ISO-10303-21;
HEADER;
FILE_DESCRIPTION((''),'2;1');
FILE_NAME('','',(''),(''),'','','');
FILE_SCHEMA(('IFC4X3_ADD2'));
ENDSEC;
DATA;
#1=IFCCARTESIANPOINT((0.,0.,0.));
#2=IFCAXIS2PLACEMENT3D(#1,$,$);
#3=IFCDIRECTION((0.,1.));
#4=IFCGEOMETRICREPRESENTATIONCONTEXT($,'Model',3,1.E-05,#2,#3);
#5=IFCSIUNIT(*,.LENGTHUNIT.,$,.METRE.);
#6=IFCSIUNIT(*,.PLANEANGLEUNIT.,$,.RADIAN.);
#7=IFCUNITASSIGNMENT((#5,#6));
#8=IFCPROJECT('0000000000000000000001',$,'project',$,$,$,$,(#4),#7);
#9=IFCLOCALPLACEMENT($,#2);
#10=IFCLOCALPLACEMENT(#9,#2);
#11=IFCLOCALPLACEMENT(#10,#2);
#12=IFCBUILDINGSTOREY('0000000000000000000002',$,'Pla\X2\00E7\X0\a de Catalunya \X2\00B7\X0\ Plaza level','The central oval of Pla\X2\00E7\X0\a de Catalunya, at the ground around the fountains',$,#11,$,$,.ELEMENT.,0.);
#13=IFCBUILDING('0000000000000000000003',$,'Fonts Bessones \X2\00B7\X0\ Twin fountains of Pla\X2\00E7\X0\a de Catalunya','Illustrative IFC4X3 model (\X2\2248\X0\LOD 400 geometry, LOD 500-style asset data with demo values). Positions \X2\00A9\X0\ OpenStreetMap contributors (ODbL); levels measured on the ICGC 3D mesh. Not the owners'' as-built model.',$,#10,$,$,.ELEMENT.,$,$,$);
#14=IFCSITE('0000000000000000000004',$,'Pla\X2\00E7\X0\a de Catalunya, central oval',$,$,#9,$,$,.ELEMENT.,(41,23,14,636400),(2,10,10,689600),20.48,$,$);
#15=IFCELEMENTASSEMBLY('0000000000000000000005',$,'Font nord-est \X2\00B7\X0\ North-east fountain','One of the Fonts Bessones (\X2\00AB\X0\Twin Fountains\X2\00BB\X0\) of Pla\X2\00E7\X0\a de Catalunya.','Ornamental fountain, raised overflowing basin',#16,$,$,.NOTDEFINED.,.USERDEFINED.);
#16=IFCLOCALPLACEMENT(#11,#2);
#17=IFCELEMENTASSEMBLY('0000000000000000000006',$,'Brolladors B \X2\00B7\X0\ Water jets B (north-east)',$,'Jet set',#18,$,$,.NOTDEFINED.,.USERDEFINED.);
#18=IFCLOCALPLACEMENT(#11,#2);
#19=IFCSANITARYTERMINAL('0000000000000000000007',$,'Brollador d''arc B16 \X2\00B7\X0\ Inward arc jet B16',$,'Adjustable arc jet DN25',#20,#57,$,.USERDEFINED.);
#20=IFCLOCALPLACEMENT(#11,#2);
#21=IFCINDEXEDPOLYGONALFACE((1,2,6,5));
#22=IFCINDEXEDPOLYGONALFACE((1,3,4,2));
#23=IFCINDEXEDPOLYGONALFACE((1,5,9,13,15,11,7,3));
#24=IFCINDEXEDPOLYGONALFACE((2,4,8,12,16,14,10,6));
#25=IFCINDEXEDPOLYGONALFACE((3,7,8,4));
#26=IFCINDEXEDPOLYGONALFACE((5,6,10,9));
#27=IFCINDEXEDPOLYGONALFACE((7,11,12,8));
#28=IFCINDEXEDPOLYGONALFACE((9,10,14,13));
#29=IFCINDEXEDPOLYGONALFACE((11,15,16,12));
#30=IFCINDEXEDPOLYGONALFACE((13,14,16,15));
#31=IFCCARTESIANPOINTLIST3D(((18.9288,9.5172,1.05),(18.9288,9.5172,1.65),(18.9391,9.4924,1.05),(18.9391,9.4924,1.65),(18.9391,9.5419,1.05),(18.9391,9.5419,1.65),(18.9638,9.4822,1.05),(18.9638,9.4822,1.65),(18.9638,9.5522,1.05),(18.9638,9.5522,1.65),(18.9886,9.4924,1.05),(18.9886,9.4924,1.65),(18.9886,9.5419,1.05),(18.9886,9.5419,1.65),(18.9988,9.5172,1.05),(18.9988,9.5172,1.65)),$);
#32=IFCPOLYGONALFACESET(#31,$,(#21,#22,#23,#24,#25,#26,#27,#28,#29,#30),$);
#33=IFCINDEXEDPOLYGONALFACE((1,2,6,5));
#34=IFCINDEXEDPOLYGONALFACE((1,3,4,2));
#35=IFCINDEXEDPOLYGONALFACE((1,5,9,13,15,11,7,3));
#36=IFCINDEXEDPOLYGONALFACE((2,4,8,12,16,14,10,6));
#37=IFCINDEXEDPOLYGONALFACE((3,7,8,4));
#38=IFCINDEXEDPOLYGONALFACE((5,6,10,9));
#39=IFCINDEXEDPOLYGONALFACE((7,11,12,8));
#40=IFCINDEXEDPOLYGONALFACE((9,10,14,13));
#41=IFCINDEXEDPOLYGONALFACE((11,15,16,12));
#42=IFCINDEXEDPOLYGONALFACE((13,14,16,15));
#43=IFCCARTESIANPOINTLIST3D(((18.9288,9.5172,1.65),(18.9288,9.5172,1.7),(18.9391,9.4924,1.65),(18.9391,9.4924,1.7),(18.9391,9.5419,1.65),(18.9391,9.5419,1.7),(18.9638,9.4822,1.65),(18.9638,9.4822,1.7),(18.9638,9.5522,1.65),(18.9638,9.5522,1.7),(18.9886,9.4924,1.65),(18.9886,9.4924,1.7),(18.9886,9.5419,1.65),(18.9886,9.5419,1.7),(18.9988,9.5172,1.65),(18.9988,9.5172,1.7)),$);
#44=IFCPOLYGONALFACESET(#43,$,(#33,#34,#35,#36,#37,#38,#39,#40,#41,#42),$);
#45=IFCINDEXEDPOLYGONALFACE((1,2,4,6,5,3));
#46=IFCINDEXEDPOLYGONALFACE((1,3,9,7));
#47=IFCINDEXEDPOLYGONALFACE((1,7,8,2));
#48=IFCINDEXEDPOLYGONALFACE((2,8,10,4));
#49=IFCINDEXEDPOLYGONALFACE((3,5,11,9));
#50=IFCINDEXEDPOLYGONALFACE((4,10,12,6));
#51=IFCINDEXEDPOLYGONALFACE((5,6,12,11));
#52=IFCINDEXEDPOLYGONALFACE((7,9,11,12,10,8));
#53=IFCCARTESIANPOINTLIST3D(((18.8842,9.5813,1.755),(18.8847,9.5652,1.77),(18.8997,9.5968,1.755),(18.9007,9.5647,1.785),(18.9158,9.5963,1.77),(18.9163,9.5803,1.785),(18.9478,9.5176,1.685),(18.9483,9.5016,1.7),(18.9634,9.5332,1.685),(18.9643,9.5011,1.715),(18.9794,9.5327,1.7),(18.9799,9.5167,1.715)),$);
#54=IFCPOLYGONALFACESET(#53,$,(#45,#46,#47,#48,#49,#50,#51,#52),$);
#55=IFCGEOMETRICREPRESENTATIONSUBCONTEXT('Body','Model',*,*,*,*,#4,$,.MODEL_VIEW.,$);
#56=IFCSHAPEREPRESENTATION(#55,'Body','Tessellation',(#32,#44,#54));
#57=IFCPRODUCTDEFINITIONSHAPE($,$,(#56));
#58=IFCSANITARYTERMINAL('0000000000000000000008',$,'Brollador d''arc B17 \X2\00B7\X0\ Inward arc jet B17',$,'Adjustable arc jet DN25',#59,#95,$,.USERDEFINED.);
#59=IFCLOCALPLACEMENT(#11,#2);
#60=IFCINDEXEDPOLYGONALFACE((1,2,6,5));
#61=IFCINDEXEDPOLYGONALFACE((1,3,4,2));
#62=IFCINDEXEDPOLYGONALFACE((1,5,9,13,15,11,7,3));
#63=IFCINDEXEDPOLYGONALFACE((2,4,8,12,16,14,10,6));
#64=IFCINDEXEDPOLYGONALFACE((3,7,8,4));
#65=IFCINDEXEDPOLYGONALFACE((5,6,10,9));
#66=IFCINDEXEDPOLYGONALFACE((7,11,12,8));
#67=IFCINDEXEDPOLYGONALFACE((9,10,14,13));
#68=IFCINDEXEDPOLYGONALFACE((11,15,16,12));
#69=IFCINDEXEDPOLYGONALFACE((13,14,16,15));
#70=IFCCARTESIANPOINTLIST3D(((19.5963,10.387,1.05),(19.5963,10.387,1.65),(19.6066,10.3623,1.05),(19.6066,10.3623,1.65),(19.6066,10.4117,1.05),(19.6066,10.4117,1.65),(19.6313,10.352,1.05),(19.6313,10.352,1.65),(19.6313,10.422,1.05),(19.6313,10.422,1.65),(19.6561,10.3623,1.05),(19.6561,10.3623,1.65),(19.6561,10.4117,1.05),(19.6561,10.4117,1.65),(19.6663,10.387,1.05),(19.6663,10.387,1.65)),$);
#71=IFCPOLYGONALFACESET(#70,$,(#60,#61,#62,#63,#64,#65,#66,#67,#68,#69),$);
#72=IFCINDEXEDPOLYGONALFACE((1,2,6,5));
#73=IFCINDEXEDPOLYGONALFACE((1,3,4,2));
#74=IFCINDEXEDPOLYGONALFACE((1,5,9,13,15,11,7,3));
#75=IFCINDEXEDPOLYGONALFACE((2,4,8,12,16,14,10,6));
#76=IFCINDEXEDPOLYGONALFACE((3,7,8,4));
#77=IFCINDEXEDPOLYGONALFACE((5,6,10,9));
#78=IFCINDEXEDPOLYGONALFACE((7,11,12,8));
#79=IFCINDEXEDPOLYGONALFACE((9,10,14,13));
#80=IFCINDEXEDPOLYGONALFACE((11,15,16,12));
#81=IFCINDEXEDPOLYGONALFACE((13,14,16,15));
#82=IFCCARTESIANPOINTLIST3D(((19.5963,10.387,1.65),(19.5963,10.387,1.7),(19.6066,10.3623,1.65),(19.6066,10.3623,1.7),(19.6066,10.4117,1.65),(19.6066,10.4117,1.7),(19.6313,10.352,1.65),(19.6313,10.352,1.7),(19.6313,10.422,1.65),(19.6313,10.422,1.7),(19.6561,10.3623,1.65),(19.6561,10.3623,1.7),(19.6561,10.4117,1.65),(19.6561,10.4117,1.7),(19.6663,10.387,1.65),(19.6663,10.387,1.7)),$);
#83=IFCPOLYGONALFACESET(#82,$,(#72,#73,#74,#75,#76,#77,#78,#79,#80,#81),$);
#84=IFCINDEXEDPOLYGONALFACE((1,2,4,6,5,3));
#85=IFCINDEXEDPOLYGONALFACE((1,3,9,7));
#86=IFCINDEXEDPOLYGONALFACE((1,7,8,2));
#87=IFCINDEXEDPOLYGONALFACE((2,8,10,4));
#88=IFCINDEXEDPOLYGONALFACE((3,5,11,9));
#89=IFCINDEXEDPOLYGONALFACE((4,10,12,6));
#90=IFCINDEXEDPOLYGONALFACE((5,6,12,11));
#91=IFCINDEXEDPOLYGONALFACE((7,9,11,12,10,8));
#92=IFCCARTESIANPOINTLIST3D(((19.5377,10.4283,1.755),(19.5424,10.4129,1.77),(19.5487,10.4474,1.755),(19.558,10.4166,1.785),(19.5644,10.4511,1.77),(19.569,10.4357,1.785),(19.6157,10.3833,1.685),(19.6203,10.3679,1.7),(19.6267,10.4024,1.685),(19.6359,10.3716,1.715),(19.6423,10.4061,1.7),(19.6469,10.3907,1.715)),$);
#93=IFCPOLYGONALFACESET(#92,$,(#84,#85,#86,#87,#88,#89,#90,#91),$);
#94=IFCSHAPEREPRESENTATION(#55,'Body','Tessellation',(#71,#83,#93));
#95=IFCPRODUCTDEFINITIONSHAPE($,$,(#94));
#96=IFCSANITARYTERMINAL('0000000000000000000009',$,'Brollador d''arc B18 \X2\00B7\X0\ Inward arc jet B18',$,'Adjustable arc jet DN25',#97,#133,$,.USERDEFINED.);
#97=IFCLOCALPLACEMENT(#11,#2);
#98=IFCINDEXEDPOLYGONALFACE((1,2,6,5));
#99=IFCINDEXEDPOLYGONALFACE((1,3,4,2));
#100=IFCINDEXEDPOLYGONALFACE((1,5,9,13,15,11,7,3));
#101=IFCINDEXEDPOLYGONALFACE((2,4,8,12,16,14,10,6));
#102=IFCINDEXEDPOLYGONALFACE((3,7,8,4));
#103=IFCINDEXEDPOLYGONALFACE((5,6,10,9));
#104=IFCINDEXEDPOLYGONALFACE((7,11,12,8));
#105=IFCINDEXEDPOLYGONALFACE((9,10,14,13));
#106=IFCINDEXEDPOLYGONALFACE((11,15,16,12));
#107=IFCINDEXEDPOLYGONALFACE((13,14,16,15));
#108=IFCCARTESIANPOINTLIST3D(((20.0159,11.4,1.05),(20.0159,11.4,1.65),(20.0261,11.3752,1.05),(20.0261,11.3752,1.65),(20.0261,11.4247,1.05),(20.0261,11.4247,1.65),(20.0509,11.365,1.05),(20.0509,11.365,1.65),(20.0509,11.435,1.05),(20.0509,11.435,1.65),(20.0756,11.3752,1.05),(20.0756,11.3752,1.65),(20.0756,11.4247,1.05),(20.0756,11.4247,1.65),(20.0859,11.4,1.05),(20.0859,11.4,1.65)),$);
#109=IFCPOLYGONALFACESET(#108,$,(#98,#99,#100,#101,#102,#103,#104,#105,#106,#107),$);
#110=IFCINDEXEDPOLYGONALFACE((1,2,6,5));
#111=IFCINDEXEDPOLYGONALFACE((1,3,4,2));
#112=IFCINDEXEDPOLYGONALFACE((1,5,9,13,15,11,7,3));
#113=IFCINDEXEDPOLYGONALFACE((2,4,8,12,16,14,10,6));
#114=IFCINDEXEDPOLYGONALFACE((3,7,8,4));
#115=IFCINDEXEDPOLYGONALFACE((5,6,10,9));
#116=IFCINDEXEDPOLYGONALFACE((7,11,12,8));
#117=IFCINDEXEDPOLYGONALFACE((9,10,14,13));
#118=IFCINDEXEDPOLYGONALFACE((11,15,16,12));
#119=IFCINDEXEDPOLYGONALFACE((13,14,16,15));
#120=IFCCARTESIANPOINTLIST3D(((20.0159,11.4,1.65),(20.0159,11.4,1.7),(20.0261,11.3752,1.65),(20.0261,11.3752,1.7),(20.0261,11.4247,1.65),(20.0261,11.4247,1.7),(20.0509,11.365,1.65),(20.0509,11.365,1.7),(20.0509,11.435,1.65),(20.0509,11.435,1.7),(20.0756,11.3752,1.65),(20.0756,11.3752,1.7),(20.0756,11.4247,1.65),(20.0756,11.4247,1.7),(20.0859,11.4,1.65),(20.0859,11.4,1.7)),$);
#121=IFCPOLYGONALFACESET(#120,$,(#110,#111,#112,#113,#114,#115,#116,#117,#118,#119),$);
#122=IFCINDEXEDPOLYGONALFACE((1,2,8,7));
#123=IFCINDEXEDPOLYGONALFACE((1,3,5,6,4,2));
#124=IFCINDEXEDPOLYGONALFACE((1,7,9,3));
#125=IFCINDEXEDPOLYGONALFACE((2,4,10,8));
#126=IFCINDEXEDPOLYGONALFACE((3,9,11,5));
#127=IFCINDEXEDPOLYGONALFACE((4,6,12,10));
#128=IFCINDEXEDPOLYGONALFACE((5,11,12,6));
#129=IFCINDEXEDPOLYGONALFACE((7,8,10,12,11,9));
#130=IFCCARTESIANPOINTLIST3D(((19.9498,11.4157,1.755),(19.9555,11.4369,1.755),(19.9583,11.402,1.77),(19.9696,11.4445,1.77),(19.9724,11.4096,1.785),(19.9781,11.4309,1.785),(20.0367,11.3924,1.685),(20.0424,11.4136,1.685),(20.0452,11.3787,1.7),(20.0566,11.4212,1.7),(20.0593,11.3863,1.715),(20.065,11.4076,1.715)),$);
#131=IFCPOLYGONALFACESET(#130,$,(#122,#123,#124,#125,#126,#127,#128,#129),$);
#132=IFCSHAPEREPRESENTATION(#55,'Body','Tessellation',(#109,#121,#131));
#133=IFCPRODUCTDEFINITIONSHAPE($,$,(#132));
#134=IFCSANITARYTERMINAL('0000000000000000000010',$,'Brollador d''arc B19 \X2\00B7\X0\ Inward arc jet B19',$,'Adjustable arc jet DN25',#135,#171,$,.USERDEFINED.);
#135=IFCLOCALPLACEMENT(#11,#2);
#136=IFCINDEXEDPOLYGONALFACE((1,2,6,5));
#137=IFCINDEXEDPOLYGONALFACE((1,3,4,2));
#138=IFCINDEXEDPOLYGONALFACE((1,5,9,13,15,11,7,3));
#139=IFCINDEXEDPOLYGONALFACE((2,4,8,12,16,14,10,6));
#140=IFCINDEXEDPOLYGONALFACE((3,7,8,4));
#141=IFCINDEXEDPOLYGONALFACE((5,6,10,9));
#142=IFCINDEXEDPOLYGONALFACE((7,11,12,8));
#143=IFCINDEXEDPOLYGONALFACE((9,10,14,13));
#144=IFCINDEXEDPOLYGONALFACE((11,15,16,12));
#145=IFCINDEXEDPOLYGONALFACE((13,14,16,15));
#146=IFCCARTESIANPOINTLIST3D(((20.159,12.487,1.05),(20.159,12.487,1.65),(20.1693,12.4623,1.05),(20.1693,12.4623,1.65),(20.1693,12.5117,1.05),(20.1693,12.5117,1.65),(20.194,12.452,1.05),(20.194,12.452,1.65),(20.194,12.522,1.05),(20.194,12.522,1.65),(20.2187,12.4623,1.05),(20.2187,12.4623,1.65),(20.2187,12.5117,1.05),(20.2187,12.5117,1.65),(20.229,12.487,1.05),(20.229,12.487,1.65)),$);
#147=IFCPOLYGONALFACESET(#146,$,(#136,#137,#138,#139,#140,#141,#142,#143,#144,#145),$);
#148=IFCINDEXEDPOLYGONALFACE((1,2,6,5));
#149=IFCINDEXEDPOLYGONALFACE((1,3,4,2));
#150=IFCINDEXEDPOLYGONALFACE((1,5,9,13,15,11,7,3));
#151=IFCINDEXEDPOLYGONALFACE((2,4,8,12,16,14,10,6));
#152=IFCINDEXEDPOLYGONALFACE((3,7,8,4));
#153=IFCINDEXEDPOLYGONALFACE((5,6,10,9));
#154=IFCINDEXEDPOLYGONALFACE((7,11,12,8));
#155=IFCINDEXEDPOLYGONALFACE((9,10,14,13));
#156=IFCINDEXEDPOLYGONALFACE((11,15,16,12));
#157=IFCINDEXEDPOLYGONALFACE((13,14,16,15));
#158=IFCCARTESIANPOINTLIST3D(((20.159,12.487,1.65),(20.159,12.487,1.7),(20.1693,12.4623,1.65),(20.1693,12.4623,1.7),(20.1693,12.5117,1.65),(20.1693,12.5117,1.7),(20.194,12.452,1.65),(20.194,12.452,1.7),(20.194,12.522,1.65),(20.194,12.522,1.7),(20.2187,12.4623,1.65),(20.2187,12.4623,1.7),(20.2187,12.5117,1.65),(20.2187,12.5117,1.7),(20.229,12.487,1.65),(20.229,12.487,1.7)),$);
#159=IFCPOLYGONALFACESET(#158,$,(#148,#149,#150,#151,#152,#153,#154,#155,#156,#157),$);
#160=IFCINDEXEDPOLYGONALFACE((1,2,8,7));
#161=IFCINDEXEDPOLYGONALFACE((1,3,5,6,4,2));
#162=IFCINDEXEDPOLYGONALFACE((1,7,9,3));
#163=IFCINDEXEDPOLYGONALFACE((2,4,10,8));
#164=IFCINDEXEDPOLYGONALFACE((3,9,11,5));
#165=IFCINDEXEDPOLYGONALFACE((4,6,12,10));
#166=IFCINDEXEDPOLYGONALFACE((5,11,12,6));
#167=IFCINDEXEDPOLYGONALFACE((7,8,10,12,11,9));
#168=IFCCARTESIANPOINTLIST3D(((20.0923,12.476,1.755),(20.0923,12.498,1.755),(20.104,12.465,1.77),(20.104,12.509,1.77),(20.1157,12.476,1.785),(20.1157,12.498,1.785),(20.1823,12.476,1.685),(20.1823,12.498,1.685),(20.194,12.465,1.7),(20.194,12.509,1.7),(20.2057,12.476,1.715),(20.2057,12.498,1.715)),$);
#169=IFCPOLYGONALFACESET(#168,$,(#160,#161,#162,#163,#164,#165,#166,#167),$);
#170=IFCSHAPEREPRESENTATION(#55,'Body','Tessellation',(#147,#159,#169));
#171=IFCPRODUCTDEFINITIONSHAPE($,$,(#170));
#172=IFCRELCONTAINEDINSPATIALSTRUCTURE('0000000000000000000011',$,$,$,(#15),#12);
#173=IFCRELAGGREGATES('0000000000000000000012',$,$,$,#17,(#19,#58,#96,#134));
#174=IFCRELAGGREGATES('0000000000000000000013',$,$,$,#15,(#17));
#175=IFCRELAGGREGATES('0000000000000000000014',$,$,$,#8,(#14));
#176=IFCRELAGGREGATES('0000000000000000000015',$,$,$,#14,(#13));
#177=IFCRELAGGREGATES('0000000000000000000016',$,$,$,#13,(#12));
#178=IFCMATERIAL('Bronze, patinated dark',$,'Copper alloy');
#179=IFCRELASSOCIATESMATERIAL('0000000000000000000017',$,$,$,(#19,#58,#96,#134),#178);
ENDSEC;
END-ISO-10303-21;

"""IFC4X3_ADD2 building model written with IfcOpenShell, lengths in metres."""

from ifc_helpers import new_model, si_unit, direction, frame, origin, place, context, subcontext, project, spatial, polyline, outline, extrude, material, element, aggregate, save


model = new_model("IFC4X3_ADD2")

# Units and contexts
model_context = context("Model", 3, precision=1e-05, world=origin(), true_north=direction((0.0, 1.0)))
body_context = subcontext(model_context, "Body", "Model", "MODEL_VIEW")
ifc_project = project(units=[si_unit("LENGTHUNIT", "METRE"), si_unit("PLANEANGLEUNIT", "RADIAN")], contexts=[model_context])

# Site, building, storey
site_placement = place(None, origin())
site = spatial("IfcSite", under=ifc_project, at=site_placement, Name="Plaça de Catalunya, central oval", CompositionType="ELEMENT", RefLatitude=(41, 23, 14, 636400), RefLongitude=(2, 10, 10, 689600), RefElevation=20.48)
building_placement = place(site_placement, origin())
building = spatial("IfcBuilding", under=site, at=building_placement, Name="Fonts Bessones · Twin fountains of Plaça de Catalunya", Description="Illustrative IFC4X3 model (≈LOD 400 geometry, LOD 500-style asset data with demo values). Positions © OpenStreetMap contributors (ODbL); levels measured on the ICGC 3D mesh. Not the owners' as-built model.", CompositionType="ELEMENT")
storey_placement = place(building_placement, origin())
storey = spatial("IfcBuildingStorey", under=building, at=storey_placement, Name="Plaça de Catalunya · Plaza level", Description="The central oval of Plaça de Catalunya, at the ground around the fountains", CompositionType="ELEMENT", Elevation=0.0)

# Element assemblies, sanitary terminals
assembly_1_placement = place(building_placement, origin())
assembly_1 = element("IfcElementAssembly", 1, at=assembly_1_placement, inside=storey, Name="Font nord-est · North-east fountain", Description="One of the Fonts Bessones («Twin Fountains») of Plaça de Catalunya.", ObjectType="Ornamental fountain, raised overflowing basin", AssemblyPlace="NOTDEFINED", PredefinedType="USERDEFINED")
assembly_2_placement = place(building_placement, origin())
assembly_2 = element("IfcElementAssembly", 2, at=assembly_2_placement, Name="Brolladors B · Water jets B (north-east)", ObjectType="Jet set", AssemblyPlace="NOTDEFINED", PredefinedType="USERDEFINED")
ifc_material_1 = material(Name="Bronze, patinated dark", Category="Copper alloy")
sanitary_terminal_1_placement = place(building_placement, origin())
sanitary_terminal_1 = element("IfcSanitaryTerminal", 3, at=sanitary_terminal_1_placement, material=ifc_material_1, Name="Brollador d'arc B16 · Inward arc jet B16", ObjectType="Adjustable arc jet DN25", PredefinedType="USERDEFINED", context=body_context, shape_type="SweptSolid", body=[
    extrude(outline(polyline([(18.9988, 9.5172), (18.9886, 9.5419), (18.9638, 9.5522), (18.9391, 9.5419), (18.9288, 9.5172), (18.9391, 9.4924), (18.9638, 9.4822), (18.9886, 9.4924), (18.9988, 9.5172)])), frame((0.0, 0.0, 1.05)), (0.0, 0.0, 1.0), 0.6),
    extrude(outline(polyline([(18.9988, 9.5172), (18.9886, 9.5419), (18.9638, 9.5522), (18.9391, 9.5419), (18.9288, 9.5172), (18.9391, 9.4924), (18.9638, 9.4822), (18.9886, 9.4924), (18.9988, 9.5172)])), frame((0.0, 0.0, 1.65)), (0.0, 0.0, 1.0), 0.05),
    extrude(outline(polyline([(0.022, 0.0), (0.011, 0.0191), (-0.011, 0.0191), (-0.022, 0.0), (-0.011, -0.0191), (0.011, -0.0191), (0.022, 0.0)])), frame((18.9638, 9.5172, 1.7), z_axis=(-0.558156, 0.558156, 0.613941), x_axis=(0.707107, 0.707107, 0.0)), (0.0, 0.0, 1.0), 0.114),
])
sanitary_terminal_2_placement = place(building_placement, origin())
sanitary_terminal_2 = element("IfcSanitaryTerminal", 4, at=sanitary_terminal_2_placement, material=ifc_material_1, Name="Brollador d'arc B17 · Inward arc jet B17", ObjectType="Adjustable arc jet DN25", PredefinedType="USERDEFINED", context=body_context, shape_type="SweptSolid", body=[
    extrude(outline(polyline([(19.6663, 10.387), (19.6561, 10.4117), (19.6313, 10.422), (19.6066, 10.4117), (19.5963, 10.387), (19.6066, 10.3623), (19.6313, 10.352), (19.6561, 10.3623), (19.6663, 10.387)])), frame((0.0, 0.0, 1.05)), (0.0, 0.0, 1.0), 0.6),
    extrude(outline(polyline([(19.6663, 10.387), (19.6561, 10.4117), (19.6313, 10.422), (19.6066, 10.4117), (19.5963, 10.387), (19.6066, 10.3623), (19.6313, 10.352), (19.6561, 10.3623), (19.6663, 10.387)])), frame((0.0, 0.0, 1.65)), (0.0, 0.0, 1.0), 0.05),
    extrude(outline(polyline([(0.022, 0.0), (0.011, 0.0191), (-0.011, 0.0191), (-0.022, 0.0), (-0.011, -0.0191), (0.011, -0.0191), (0.022, 0.0)])), frame((19.6313, 10.387, 1.7), z_axis=(-0.683599, 0.394676, 0.613941), x_axis=(0.5, 0.866025, 0.0)), (0.0, 0.0, 1.0), 0.114),
])
sanitary_terminal_3_placement = place(building_placement, origin())
sanitary_terminal_3 = element("IfcSanitaryTerminal", 5, at=sanitary_terminal_3_placement, material=ifc_material_1, Name="Brollador d'arc B18 · Inward arc jet B18", ObjectType="Adjustable arc jet DN25", PredefinedType="USERDEFINED", context=body_context, shape_type="SweptSolid", body=[
    extrude(outline(polyline([(20.0859, 11.4), (20.0756, 11.4247), (20.0509, 11.435), (20.0261, 11.4247), (20.0159, 11.4), (20.0261, 11.3752), (20.0509, 11.365), (20.0756, 11.3752), (20.0859, 11.4)])), frame((0.0, 0.0, 1.05)), (0.0, 0.0, 1.0), 0.6),
    extrude(outline(polyline([(20.0859, 11.4), (20.0756, 11.4247), (20.0509, 11.435), (20.0261, 11.4247), (20.0159, 11.4), (20.0261, 11.3752), (20.0509, 11.365), (20.0756, 11.3752), (20.0859, 11.4)])), frame((0.0, 0.0, 1.65)), (0.0, 0.0, 1.0), 0.05),
    extrude(outline(polyline([(0.022, 0.0), (0.011, 0.0191), (-0.011, 0.0191), (-0.022, 0.0), (-0.011, -0.0191), (0.011, -0.0191), (0.022, 0.0)])), frame((20.0509, 11.4, 1.7), z_axis=(-0.762456, 0.204299, 0.613941), x_axis=(0.258819, 0.965926, 0.0)), (0.0, 0.0, 1.0), 0.114),
])
sanitary_terminal_4_placement = place(building_placement, origin())
sanitary_terminal_4 = element("IfcSanitaryTerminal", 6, at=sanitary_terminal_4_placement, material=ifc_material_1, Name="Brollador d'arc B19 · Inward arc jet B19", ObjectType="Adjustable arc jet DN25", PredefinedType="USERDEFINED", context=body_context, shape_type="SweptSolid", body=[
    extrude(outline(polyline([(20.229, 12.487), (20.2187, 12.5117), (20.194, 12.522), (20.1693, 12.5117), (20.159, 12.487), (20.1693, 12.4623), (20.194, 12.452), (20.2187, 12.4623), (20.229, 12.487)])), frame((0.0, 0.0, 1.05)), (0.0, 0.0, 1.0), 0.6),
    extrude(outline(polyline([(20.229, 12.487), (20.2187, 12.5117), (20.194, 12.522), (20.1693, 12.5117), (20.159, 12.487), (20.1693, 12.4623), (20.194, 12.452), (20.2187, 12.4623), (20.229, 12.487)])), frame((0.0, 0.0, 1.65)), (0.0, 0.0, 1.0), 0.05),
    extrude(outline(polyline([(0.022, 0.0), (0.011, 0.0191), (-0.011, 0.0191), (-0.022, 0.0), (-0.011, -0.0191), (0.011, -0.0191), (0.022, 0.0)])), frame((20.194, 12.487, 1.7), z_axis=(-0.789352, 0.0, 0.613941), x_axis=(0.0, 1.0, 0.0)), (0.0, 0.0, 1.0), 0.114),
])
aggregate(assembly_2, [sanitary_terminal_1, sanitary_terminal_2, sanitary_terminal_3, sanitary_terminal_4])
aggregate(assembly_1, [assembly_2])

save(model, "model.ifc")
